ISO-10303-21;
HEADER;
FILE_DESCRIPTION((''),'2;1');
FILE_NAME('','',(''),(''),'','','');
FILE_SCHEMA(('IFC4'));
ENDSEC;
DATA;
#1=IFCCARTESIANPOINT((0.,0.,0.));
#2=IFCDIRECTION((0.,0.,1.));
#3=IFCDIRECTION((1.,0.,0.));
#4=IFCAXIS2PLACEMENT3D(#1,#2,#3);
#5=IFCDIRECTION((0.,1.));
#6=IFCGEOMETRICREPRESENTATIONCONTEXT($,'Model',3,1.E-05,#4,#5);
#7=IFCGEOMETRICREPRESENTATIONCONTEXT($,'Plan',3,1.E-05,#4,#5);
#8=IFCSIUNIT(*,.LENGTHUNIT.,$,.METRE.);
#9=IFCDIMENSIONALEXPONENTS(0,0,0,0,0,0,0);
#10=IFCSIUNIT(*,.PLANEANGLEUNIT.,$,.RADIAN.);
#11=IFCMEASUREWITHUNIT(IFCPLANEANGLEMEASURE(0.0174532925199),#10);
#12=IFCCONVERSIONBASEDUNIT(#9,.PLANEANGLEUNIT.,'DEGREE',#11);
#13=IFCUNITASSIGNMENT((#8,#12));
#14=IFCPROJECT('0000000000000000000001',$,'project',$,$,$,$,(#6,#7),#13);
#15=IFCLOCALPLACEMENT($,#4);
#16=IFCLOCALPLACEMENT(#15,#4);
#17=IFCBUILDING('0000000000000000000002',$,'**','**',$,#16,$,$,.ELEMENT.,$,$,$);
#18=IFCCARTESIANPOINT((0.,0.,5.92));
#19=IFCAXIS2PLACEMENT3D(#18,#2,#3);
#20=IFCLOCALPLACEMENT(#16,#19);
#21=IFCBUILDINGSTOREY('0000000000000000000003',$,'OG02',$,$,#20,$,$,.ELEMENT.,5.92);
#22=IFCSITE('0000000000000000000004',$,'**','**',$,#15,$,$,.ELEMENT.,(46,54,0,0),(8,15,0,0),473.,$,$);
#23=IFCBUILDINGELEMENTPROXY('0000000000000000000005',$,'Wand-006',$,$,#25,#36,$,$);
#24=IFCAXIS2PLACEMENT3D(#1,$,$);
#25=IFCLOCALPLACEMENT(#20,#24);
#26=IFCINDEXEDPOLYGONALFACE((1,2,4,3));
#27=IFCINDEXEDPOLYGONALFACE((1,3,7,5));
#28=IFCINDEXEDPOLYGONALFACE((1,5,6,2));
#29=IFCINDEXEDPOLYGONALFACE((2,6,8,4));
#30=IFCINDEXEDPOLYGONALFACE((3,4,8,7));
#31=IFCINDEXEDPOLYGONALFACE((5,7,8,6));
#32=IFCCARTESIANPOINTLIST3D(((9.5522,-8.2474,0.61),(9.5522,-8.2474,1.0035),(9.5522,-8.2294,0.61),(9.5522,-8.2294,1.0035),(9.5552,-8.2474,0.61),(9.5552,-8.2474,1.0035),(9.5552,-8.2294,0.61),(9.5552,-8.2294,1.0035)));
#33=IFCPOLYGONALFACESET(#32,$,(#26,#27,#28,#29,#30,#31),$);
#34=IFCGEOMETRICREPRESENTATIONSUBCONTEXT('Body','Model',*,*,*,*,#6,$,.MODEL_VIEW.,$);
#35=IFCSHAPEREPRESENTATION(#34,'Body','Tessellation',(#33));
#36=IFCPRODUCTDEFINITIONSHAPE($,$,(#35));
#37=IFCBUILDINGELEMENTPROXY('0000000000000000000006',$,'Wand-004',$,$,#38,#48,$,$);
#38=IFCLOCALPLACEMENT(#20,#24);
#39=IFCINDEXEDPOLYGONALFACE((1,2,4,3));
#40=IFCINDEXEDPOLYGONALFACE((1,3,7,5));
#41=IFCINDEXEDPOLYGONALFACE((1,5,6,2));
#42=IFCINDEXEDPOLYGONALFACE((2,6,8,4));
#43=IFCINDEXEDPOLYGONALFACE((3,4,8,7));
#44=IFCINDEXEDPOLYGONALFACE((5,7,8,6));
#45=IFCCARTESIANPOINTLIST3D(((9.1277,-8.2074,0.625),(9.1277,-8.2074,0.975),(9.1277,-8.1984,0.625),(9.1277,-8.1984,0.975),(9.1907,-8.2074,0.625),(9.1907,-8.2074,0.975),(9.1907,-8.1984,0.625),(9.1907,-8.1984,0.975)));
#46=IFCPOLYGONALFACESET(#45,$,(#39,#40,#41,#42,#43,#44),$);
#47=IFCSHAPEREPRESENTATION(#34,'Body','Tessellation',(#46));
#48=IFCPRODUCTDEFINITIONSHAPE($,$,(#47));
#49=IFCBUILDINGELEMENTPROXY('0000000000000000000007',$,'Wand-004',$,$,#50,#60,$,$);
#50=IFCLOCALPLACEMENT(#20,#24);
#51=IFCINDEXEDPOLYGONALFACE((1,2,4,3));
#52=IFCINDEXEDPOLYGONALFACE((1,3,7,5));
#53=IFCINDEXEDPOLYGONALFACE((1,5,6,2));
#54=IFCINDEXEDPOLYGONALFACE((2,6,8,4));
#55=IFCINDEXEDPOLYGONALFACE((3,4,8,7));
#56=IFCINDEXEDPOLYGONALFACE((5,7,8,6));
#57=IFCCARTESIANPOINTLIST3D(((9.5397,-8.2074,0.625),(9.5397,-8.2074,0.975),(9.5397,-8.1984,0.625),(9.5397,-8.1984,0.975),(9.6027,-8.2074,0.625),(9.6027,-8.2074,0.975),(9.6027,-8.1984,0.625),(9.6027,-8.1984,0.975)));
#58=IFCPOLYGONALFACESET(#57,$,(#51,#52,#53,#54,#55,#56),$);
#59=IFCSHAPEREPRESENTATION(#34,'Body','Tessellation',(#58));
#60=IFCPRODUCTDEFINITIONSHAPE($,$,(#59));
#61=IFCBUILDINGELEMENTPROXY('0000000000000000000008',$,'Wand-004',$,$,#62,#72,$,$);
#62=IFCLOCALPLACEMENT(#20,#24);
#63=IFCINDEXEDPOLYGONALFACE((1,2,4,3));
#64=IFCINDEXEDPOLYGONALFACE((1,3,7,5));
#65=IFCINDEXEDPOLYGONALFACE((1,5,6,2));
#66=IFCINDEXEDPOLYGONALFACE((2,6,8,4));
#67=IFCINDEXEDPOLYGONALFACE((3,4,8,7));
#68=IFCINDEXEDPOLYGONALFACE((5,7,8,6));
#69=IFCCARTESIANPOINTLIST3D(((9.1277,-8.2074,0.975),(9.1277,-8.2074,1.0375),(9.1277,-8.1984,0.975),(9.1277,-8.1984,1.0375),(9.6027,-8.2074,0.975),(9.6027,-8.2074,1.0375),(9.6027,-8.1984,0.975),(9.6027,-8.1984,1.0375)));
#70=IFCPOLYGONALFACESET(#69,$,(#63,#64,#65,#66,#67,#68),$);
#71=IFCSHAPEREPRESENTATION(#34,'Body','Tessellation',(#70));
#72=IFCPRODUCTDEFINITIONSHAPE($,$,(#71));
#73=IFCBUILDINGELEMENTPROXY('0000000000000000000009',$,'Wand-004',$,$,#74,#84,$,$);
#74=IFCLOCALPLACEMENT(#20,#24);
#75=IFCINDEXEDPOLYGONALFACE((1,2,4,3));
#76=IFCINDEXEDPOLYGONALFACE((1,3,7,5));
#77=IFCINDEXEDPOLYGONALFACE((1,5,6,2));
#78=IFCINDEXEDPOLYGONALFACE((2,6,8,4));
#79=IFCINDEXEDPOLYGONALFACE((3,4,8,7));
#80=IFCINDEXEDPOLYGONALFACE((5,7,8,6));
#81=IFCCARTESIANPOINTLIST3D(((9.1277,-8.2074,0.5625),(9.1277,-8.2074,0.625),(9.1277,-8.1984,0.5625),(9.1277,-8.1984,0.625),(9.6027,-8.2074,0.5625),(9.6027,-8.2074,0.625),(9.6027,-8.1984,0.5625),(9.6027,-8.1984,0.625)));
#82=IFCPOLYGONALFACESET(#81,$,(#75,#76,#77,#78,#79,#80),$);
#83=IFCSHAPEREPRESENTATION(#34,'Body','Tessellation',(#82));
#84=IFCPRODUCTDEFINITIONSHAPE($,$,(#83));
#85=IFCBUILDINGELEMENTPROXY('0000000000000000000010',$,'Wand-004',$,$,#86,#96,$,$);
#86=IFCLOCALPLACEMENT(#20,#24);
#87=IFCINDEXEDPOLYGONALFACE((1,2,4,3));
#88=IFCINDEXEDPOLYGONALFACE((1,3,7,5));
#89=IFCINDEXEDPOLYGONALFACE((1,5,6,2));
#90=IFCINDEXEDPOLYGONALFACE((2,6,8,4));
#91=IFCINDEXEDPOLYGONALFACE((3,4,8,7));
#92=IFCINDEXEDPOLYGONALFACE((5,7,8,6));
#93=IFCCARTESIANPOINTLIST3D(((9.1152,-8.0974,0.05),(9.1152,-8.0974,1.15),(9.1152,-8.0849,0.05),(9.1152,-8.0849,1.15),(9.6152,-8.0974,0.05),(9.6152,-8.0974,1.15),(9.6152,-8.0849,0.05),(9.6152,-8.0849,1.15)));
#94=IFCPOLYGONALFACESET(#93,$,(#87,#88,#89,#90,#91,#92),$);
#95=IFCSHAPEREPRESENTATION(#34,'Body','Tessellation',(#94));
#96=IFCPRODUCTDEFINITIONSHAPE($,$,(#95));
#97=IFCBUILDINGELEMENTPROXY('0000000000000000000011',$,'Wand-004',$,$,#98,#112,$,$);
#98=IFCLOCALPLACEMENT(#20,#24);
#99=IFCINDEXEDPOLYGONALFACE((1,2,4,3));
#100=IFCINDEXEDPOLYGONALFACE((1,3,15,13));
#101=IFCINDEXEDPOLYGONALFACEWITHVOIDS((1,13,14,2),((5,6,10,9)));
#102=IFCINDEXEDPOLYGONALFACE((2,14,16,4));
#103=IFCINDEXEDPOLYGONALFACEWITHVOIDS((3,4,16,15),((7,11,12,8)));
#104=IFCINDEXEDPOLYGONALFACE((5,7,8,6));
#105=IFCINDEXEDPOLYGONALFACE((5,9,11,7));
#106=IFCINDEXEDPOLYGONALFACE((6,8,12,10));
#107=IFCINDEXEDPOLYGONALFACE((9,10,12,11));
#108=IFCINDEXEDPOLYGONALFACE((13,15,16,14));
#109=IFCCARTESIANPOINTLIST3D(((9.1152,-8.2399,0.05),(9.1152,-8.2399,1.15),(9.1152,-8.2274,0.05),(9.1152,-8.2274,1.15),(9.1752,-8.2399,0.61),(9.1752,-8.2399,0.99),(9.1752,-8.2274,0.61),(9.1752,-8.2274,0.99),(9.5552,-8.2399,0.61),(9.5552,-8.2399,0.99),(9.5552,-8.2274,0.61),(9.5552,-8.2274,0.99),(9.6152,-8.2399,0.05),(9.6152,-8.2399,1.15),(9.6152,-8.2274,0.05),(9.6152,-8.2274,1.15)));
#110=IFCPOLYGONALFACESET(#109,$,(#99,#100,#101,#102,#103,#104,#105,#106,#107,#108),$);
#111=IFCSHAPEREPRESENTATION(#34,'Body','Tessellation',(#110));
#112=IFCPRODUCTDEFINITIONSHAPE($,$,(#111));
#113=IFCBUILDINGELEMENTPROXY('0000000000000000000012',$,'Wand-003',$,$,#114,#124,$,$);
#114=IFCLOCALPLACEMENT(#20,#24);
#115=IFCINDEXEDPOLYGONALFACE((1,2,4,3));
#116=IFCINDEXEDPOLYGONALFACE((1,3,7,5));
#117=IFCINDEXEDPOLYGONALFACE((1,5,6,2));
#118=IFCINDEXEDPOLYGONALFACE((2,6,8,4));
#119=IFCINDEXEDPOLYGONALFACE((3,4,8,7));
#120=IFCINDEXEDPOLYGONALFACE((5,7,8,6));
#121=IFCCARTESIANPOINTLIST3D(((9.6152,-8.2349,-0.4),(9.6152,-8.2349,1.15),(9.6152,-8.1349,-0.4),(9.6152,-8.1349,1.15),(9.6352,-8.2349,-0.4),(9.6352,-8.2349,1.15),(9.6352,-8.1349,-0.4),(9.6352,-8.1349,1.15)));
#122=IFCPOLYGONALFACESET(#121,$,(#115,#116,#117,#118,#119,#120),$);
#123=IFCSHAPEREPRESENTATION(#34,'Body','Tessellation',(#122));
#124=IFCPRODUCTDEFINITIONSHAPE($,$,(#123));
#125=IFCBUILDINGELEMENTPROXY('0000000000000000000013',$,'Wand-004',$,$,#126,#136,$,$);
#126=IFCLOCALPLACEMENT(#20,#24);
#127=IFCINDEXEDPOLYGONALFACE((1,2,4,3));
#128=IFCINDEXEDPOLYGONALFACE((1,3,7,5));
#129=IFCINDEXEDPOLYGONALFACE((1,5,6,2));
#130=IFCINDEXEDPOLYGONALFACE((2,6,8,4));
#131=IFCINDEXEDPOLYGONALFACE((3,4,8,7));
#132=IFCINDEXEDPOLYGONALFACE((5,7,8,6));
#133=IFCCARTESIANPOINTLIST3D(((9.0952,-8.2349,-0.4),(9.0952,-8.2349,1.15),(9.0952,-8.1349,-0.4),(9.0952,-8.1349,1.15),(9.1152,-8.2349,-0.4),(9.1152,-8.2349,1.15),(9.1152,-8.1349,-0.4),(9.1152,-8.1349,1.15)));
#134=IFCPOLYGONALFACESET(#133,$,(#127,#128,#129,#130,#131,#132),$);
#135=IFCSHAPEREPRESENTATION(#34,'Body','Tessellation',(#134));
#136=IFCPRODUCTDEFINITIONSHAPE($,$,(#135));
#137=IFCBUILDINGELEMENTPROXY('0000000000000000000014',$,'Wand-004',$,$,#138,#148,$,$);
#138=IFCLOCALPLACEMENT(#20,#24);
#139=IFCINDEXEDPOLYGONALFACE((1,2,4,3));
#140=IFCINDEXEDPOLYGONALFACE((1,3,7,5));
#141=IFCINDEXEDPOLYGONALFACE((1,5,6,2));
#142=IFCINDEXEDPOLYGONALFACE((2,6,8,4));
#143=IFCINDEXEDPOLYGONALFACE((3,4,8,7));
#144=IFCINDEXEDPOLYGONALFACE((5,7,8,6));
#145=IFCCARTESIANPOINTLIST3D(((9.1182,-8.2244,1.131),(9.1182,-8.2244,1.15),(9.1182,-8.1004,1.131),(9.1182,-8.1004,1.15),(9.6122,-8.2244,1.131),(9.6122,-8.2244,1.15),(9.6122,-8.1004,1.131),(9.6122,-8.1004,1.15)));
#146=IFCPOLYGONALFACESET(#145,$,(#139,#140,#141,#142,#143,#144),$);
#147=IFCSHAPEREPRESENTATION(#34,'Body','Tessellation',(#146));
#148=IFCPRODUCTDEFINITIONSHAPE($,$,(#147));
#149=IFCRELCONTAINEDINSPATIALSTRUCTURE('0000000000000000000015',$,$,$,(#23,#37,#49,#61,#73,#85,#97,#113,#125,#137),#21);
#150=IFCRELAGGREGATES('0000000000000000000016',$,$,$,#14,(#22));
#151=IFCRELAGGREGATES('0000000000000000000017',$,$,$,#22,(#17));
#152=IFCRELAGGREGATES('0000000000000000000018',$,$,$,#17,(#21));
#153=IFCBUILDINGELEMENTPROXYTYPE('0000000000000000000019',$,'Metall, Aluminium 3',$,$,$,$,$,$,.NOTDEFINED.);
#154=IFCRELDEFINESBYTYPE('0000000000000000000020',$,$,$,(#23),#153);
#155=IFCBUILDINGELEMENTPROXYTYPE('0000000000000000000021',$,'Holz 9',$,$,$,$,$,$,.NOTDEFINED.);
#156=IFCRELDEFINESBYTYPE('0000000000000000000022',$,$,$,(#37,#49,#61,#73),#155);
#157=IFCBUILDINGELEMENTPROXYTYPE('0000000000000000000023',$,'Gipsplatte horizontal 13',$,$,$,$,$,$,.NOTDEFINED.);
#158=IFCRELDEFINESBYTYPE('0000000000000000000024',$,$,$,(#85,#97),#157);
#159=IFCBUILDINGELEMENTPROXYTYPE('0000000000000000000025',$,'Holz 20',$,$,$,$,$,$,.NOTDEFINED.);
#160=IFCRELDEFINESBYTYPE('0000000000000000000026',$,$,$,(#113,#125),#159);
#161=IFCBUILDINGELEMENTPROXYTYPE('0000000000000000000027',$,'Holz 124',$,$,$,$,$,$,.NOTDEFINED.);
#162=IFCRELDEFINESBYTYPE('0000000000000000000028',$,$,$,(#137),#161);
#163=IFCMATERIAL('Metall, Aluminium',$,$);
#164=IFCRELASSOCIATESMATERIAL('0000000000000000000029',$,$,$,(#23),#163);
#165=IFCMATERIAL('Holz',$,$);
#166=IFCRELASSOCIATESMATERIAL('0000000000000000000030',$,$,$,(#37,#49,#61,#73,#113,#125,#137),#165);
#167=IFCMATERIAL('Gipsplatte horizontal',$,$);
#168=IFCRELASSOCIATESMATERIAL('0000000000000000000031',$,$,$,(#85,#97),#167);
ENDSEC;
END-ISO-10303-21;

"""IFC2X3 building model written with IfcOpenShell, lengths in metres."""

from ifc_helpers import new_model, entity, si_unit, converted_unit, direction, frame, origin_with_axes, origin_2d_with_axis, place, context, subcontext, project, spatial, polyline, rectangle, outline, extrude, material, type_object, element, save


model = new_model("IFC2X3")

# Units and contexts
model_context = context("Model", 3, precision=1e-05, world=origin_with_axes(), true_north=direction((0.0, 1.0)))
plan_context = context("Plan", 3, precision=1e-05, world=origin_with_axes(), true_north=direction((0.0, 1.0)))
body_context = subcontext(model_context, "Body", "Model", "MODEL_VIEW")
ifc_project = project(units=[si_unit("LENGTHUNIT", "METRE"), converted_unit("PLANEANGLEUNIT", "DEGREE", entity("IfcPlaneAngleMeasure", 0.0174532925199), si_unit("PLANEANGLEUNIT", "RADIAN"), dimensions=[0, 0, 0, 0, 0, 0, 0])], contexts=[model_context, plan_context])

# Site, building, storey
site_placement = place(None, origin_with_axes())
site = spatial("IfcSite", under=ifc_project, at=site_placement, Name="**", Description="**", CompositionType="ELEMENT", RefLatitude=(46, 54, 0, 0), RefLongitude=(8, 15, 0, 0), RefElevation=473.0)
building_placement = place(site_placement, origin_with_axes())
building = spatial("IfcBuilding", under=site, at=building_placement, Name="**", Description="**", CompositionType="ELEMENT")
storey_placement = place(building_placement, frame((0.0, 0.0, 5.92), z_axis=(0.0, 0.0, 1.0), x_axis=(1.0, 0.0, 0.0)))
storey = spatial("IfcBuildingStorey", under=building, at=storey_placement, Name="OG02", CompositionType="ELEMENT", Elevation=5.92)

# Building element proxies
ifc_material_1 = material(Name="Holz")
ifc_material_2 = material(Name="Metall, Aluminium")
building_element_proxy_type_1 = type_object("IfcBuildingElementProxyType", Name="Metall, Aluminium 3", PredefinedType="NOTDEFINED")
proxy_1_placement = place(storey_placement, frame((9.5552, -8.2294, 0.61), z_axis=(0.0, 0.0, 1.0), x_axis=(0.0, -1.0, 0.0)))
element("IfcBuildingElementProxy", 1, at=proxy_1_placement, inside=storey, type_object=building_element_proxy_type_1, material=ifc_material_2, Name="Wand-006", context=body_context, shape_type="SweptSolid", body=[
    extrude(outline(polyline([(0.0, -0.003), (0.018, -0.003), (0.018, 0.0), (0.0, 0.0), (0.0, -0.003)])), origin_with_axes(), (0.0, 0.0, 1.0), 0.3935),
])
building_element_proxy_type_2 = type_object("IfcBuildingElementProxyType", Name="Holz 9", PredefinedType="NOTDEFINED")
for number, where, z_axis, x_axis, name in (
    (2, (9.1277, -8.2074, 0.625), (0.0, 0.0, 1.0), (1.0, 0.0, 0.0), "Wand-004"),
    (3, (9.5397, -8.2074, 0.625), (0.0, 0.0, 1.0), (1.0, 0.0, 0.0), "Wand-004"),
):
    element("IfcBuildingElementProxy", number, at=place(storey_placement, frame(where, z_axis=z_axis, x_axis=x_axis)), inside=storey, type_object=building_element_proxy_type_2, material=ifc_material_1, Name=name, context=body_context, shape_type="SweptSolid", body=[
        extrude(outline(polyline([(0.0, 0.0), (0.063, 0.0), (0.063, 0.009), (0.0, 0.009), (0.0, 0.0)])), origin_with_axes(), (0.0, 0.0, 1.0), 0.35),
    ])
for number, where, z_axis, x_axis, name in (
    (4, (9.6027, -8.2074, 0.975), (0.0, 0.0, 1.0), (-1.0, 0.0, 0.0), "Wand-004"),
    (5, (9.6027, -8.2074, 0.5625), (0.0, 0.0, 1.0), (-1.0, 0.0, 0.0), "Wand-004"),
):
    element("IfcBuildingElementProxy", number, at=place(storey_placement, frame(where, z_axis=z_axis, x_axis=x_axis)), inside=storey, type_object=building_element_proxy_type_2, material=ifc_material_1, Name=name, context=body_context, shape_type="SweptSolid", body=[
        extrude(outline(polyline([(0.0, -0.009), (0.475, -0.009), (0.475, 0.0), (0.0, 0.0), (0.0, -0.009)])), origin_with_axes(), (0.0, 0.0, 1.0), 0.0625),
    ])
ifc_material_3 = material(Name="Gipsplatte horizontal")
building_element_proxy_type_3 = type_object("IfcBuildingElementProxyType", Name="Gipsplatte horizontal 13", PredefinedType="NOTDEFINED")
proxy_2_placement = place(storey_placement, frame((9.1152, -8.0849, 0.05), z_axis=(0.0, 0.0, 1.0), x_axis=(1.0, 0.0, 0.0)))
element("IfcBuildingElementProxy", 6, at=proxy_2_placement, inside=storey, type_object=building_element_proxy_type_3, material=ifc_material_3, Name="Wand-004", context=body_context, shape_type="SweptSolid", body=[
    extrude(outline(polyline([(0.0, -0.0125), (0.5, -0.0125), (0.5, 0.0), (0.0, 0.0), (0.0, -0.0125)])), origin_with_axes(), (0.0, 0.0, 1.0), 1.1),
])

# Building element proxy, opening
proxy_3_placement = place(storey_placement, frame((9.1152, -8.2399, 0.05), z_axis=(0.0, 0.0, 1.0), x_axis=(1.0, 0.0, 0.0)))
proxy_3 = element("IfcBuildingElementProxy", 7, at=proxy_3_placement, inside=storey, type_object=building_element_proxy_type_3, material=ifc_material_3, Name="Wand-004", context=body_context, shape_type="SweptSolid", body=[
    extrude(outline(polyline([(0.0, 0.0), (0.5, 0.0), (0.5, 0.0125), (0.0, 0.0125), (0.0, 0.0)])), origin_with_axes(), (0.0, 0.0, 1.0), 1.1),
])
opening_placement = place(proxy_3_placement, frame((-9.1152, 8.2399, -5.97), z_axis=(0.0, 0.0, 1.0), x_axis=(1.0, 0.0, 0.0)))
element("IfcOpeningElement", 8, at=opening_placement, cuts=proxy_3, context=body_context, shape_type="SweptSolid", body=[
    extrude(rectangle(XDim=0.38, YDim=0.38, at=origin_2d_with_axis()), frame((9.3652, -8.2524, 6.72), z_axis=(0.0, -1.0, 0.0), x_axis=(1.0, 0.0, 0.0)), (0.0, 0.0, -1.0), 0.0375),
])

# Building element proxies
building_element_proxy_type_4 = type_object("IfcBuildingElementProxyType", Name="Holz 20", PredefinedType="NOTDEFINED")
proxy_4_placement = place(storey_placement, frame((9.6352, -8.1349, -0.4), z_axis=(0.0, 0.0, 1.0), x_axis=(0.0, -1.0, 0.0)))
element("IfcBuildingElementProxy", 9, at=proxy_4_placement, inside=storey, type_object=building_element_proxy_type_4, material=ifc_material_1, Name="Wand-003", context=body_context, shape_type="SweptSolid", body=[
    extrude(outline(polyline([(0.0, -0.02), (0.1, -0.02), (0.1, 0.0), (0.0, 0.0), (0.0, -0.02)])), origin_with_axes(), (0.0, 0.0, 1.0), 1.55),
])
proxy_5_placement = place(storey_placement, frame((9.0952, -8.1349, -0.4), z_axis=(0.0, 0.0, 1.0), x_axis=(0.0, -1.0, 0.0)))
element("IfcBuildingElementProxy", 10, at=proxy_5_placement, inside=storey, type_object=building_element_proxy_type_4, material=ifc_material_1, Name="Wand-004", context=body_context, shape_type="SweptSolid", body=[
    extrude(outline(polyline([(0.0, 0.0), (0.1, 0.0), (0.1, 0.02), (0.0, 0.02), (0.0, 0.0)])), origin_with_axes(), (0.0, 0.0, 1.0), 1.55),
])
building_element_proxy_type_5 = type_object("IfcBuildingElementProxyType", Name="Holz 124", PredefinedType="NOTDEFINED")
proxy_6_placement = place(storey_placement, frame((9.1182, -8.1004, 1.131), z_axis=(0.0, 0.0, 1.0), x_axis=(1.0, 0.0, 0.0)))
element("IfcBuildingElementProxy", 11, at=proxy_6_placement, inside=storey, type_object=building_element_proxy_type_5, material=ifc_material_1, Name="Wand-004", context=body_context, shape_type="SweptSolid", body=[
    extrude(outline(polyline([(0.0, -0.124), (0.494, -0.124), (0.494, 0.0), (0.0, 0.0), (0.0, -0.124)])), origin_with_axes(), (0.0, 0.0, 1.0), 0.019),
])

save(model, "model.ifc")
